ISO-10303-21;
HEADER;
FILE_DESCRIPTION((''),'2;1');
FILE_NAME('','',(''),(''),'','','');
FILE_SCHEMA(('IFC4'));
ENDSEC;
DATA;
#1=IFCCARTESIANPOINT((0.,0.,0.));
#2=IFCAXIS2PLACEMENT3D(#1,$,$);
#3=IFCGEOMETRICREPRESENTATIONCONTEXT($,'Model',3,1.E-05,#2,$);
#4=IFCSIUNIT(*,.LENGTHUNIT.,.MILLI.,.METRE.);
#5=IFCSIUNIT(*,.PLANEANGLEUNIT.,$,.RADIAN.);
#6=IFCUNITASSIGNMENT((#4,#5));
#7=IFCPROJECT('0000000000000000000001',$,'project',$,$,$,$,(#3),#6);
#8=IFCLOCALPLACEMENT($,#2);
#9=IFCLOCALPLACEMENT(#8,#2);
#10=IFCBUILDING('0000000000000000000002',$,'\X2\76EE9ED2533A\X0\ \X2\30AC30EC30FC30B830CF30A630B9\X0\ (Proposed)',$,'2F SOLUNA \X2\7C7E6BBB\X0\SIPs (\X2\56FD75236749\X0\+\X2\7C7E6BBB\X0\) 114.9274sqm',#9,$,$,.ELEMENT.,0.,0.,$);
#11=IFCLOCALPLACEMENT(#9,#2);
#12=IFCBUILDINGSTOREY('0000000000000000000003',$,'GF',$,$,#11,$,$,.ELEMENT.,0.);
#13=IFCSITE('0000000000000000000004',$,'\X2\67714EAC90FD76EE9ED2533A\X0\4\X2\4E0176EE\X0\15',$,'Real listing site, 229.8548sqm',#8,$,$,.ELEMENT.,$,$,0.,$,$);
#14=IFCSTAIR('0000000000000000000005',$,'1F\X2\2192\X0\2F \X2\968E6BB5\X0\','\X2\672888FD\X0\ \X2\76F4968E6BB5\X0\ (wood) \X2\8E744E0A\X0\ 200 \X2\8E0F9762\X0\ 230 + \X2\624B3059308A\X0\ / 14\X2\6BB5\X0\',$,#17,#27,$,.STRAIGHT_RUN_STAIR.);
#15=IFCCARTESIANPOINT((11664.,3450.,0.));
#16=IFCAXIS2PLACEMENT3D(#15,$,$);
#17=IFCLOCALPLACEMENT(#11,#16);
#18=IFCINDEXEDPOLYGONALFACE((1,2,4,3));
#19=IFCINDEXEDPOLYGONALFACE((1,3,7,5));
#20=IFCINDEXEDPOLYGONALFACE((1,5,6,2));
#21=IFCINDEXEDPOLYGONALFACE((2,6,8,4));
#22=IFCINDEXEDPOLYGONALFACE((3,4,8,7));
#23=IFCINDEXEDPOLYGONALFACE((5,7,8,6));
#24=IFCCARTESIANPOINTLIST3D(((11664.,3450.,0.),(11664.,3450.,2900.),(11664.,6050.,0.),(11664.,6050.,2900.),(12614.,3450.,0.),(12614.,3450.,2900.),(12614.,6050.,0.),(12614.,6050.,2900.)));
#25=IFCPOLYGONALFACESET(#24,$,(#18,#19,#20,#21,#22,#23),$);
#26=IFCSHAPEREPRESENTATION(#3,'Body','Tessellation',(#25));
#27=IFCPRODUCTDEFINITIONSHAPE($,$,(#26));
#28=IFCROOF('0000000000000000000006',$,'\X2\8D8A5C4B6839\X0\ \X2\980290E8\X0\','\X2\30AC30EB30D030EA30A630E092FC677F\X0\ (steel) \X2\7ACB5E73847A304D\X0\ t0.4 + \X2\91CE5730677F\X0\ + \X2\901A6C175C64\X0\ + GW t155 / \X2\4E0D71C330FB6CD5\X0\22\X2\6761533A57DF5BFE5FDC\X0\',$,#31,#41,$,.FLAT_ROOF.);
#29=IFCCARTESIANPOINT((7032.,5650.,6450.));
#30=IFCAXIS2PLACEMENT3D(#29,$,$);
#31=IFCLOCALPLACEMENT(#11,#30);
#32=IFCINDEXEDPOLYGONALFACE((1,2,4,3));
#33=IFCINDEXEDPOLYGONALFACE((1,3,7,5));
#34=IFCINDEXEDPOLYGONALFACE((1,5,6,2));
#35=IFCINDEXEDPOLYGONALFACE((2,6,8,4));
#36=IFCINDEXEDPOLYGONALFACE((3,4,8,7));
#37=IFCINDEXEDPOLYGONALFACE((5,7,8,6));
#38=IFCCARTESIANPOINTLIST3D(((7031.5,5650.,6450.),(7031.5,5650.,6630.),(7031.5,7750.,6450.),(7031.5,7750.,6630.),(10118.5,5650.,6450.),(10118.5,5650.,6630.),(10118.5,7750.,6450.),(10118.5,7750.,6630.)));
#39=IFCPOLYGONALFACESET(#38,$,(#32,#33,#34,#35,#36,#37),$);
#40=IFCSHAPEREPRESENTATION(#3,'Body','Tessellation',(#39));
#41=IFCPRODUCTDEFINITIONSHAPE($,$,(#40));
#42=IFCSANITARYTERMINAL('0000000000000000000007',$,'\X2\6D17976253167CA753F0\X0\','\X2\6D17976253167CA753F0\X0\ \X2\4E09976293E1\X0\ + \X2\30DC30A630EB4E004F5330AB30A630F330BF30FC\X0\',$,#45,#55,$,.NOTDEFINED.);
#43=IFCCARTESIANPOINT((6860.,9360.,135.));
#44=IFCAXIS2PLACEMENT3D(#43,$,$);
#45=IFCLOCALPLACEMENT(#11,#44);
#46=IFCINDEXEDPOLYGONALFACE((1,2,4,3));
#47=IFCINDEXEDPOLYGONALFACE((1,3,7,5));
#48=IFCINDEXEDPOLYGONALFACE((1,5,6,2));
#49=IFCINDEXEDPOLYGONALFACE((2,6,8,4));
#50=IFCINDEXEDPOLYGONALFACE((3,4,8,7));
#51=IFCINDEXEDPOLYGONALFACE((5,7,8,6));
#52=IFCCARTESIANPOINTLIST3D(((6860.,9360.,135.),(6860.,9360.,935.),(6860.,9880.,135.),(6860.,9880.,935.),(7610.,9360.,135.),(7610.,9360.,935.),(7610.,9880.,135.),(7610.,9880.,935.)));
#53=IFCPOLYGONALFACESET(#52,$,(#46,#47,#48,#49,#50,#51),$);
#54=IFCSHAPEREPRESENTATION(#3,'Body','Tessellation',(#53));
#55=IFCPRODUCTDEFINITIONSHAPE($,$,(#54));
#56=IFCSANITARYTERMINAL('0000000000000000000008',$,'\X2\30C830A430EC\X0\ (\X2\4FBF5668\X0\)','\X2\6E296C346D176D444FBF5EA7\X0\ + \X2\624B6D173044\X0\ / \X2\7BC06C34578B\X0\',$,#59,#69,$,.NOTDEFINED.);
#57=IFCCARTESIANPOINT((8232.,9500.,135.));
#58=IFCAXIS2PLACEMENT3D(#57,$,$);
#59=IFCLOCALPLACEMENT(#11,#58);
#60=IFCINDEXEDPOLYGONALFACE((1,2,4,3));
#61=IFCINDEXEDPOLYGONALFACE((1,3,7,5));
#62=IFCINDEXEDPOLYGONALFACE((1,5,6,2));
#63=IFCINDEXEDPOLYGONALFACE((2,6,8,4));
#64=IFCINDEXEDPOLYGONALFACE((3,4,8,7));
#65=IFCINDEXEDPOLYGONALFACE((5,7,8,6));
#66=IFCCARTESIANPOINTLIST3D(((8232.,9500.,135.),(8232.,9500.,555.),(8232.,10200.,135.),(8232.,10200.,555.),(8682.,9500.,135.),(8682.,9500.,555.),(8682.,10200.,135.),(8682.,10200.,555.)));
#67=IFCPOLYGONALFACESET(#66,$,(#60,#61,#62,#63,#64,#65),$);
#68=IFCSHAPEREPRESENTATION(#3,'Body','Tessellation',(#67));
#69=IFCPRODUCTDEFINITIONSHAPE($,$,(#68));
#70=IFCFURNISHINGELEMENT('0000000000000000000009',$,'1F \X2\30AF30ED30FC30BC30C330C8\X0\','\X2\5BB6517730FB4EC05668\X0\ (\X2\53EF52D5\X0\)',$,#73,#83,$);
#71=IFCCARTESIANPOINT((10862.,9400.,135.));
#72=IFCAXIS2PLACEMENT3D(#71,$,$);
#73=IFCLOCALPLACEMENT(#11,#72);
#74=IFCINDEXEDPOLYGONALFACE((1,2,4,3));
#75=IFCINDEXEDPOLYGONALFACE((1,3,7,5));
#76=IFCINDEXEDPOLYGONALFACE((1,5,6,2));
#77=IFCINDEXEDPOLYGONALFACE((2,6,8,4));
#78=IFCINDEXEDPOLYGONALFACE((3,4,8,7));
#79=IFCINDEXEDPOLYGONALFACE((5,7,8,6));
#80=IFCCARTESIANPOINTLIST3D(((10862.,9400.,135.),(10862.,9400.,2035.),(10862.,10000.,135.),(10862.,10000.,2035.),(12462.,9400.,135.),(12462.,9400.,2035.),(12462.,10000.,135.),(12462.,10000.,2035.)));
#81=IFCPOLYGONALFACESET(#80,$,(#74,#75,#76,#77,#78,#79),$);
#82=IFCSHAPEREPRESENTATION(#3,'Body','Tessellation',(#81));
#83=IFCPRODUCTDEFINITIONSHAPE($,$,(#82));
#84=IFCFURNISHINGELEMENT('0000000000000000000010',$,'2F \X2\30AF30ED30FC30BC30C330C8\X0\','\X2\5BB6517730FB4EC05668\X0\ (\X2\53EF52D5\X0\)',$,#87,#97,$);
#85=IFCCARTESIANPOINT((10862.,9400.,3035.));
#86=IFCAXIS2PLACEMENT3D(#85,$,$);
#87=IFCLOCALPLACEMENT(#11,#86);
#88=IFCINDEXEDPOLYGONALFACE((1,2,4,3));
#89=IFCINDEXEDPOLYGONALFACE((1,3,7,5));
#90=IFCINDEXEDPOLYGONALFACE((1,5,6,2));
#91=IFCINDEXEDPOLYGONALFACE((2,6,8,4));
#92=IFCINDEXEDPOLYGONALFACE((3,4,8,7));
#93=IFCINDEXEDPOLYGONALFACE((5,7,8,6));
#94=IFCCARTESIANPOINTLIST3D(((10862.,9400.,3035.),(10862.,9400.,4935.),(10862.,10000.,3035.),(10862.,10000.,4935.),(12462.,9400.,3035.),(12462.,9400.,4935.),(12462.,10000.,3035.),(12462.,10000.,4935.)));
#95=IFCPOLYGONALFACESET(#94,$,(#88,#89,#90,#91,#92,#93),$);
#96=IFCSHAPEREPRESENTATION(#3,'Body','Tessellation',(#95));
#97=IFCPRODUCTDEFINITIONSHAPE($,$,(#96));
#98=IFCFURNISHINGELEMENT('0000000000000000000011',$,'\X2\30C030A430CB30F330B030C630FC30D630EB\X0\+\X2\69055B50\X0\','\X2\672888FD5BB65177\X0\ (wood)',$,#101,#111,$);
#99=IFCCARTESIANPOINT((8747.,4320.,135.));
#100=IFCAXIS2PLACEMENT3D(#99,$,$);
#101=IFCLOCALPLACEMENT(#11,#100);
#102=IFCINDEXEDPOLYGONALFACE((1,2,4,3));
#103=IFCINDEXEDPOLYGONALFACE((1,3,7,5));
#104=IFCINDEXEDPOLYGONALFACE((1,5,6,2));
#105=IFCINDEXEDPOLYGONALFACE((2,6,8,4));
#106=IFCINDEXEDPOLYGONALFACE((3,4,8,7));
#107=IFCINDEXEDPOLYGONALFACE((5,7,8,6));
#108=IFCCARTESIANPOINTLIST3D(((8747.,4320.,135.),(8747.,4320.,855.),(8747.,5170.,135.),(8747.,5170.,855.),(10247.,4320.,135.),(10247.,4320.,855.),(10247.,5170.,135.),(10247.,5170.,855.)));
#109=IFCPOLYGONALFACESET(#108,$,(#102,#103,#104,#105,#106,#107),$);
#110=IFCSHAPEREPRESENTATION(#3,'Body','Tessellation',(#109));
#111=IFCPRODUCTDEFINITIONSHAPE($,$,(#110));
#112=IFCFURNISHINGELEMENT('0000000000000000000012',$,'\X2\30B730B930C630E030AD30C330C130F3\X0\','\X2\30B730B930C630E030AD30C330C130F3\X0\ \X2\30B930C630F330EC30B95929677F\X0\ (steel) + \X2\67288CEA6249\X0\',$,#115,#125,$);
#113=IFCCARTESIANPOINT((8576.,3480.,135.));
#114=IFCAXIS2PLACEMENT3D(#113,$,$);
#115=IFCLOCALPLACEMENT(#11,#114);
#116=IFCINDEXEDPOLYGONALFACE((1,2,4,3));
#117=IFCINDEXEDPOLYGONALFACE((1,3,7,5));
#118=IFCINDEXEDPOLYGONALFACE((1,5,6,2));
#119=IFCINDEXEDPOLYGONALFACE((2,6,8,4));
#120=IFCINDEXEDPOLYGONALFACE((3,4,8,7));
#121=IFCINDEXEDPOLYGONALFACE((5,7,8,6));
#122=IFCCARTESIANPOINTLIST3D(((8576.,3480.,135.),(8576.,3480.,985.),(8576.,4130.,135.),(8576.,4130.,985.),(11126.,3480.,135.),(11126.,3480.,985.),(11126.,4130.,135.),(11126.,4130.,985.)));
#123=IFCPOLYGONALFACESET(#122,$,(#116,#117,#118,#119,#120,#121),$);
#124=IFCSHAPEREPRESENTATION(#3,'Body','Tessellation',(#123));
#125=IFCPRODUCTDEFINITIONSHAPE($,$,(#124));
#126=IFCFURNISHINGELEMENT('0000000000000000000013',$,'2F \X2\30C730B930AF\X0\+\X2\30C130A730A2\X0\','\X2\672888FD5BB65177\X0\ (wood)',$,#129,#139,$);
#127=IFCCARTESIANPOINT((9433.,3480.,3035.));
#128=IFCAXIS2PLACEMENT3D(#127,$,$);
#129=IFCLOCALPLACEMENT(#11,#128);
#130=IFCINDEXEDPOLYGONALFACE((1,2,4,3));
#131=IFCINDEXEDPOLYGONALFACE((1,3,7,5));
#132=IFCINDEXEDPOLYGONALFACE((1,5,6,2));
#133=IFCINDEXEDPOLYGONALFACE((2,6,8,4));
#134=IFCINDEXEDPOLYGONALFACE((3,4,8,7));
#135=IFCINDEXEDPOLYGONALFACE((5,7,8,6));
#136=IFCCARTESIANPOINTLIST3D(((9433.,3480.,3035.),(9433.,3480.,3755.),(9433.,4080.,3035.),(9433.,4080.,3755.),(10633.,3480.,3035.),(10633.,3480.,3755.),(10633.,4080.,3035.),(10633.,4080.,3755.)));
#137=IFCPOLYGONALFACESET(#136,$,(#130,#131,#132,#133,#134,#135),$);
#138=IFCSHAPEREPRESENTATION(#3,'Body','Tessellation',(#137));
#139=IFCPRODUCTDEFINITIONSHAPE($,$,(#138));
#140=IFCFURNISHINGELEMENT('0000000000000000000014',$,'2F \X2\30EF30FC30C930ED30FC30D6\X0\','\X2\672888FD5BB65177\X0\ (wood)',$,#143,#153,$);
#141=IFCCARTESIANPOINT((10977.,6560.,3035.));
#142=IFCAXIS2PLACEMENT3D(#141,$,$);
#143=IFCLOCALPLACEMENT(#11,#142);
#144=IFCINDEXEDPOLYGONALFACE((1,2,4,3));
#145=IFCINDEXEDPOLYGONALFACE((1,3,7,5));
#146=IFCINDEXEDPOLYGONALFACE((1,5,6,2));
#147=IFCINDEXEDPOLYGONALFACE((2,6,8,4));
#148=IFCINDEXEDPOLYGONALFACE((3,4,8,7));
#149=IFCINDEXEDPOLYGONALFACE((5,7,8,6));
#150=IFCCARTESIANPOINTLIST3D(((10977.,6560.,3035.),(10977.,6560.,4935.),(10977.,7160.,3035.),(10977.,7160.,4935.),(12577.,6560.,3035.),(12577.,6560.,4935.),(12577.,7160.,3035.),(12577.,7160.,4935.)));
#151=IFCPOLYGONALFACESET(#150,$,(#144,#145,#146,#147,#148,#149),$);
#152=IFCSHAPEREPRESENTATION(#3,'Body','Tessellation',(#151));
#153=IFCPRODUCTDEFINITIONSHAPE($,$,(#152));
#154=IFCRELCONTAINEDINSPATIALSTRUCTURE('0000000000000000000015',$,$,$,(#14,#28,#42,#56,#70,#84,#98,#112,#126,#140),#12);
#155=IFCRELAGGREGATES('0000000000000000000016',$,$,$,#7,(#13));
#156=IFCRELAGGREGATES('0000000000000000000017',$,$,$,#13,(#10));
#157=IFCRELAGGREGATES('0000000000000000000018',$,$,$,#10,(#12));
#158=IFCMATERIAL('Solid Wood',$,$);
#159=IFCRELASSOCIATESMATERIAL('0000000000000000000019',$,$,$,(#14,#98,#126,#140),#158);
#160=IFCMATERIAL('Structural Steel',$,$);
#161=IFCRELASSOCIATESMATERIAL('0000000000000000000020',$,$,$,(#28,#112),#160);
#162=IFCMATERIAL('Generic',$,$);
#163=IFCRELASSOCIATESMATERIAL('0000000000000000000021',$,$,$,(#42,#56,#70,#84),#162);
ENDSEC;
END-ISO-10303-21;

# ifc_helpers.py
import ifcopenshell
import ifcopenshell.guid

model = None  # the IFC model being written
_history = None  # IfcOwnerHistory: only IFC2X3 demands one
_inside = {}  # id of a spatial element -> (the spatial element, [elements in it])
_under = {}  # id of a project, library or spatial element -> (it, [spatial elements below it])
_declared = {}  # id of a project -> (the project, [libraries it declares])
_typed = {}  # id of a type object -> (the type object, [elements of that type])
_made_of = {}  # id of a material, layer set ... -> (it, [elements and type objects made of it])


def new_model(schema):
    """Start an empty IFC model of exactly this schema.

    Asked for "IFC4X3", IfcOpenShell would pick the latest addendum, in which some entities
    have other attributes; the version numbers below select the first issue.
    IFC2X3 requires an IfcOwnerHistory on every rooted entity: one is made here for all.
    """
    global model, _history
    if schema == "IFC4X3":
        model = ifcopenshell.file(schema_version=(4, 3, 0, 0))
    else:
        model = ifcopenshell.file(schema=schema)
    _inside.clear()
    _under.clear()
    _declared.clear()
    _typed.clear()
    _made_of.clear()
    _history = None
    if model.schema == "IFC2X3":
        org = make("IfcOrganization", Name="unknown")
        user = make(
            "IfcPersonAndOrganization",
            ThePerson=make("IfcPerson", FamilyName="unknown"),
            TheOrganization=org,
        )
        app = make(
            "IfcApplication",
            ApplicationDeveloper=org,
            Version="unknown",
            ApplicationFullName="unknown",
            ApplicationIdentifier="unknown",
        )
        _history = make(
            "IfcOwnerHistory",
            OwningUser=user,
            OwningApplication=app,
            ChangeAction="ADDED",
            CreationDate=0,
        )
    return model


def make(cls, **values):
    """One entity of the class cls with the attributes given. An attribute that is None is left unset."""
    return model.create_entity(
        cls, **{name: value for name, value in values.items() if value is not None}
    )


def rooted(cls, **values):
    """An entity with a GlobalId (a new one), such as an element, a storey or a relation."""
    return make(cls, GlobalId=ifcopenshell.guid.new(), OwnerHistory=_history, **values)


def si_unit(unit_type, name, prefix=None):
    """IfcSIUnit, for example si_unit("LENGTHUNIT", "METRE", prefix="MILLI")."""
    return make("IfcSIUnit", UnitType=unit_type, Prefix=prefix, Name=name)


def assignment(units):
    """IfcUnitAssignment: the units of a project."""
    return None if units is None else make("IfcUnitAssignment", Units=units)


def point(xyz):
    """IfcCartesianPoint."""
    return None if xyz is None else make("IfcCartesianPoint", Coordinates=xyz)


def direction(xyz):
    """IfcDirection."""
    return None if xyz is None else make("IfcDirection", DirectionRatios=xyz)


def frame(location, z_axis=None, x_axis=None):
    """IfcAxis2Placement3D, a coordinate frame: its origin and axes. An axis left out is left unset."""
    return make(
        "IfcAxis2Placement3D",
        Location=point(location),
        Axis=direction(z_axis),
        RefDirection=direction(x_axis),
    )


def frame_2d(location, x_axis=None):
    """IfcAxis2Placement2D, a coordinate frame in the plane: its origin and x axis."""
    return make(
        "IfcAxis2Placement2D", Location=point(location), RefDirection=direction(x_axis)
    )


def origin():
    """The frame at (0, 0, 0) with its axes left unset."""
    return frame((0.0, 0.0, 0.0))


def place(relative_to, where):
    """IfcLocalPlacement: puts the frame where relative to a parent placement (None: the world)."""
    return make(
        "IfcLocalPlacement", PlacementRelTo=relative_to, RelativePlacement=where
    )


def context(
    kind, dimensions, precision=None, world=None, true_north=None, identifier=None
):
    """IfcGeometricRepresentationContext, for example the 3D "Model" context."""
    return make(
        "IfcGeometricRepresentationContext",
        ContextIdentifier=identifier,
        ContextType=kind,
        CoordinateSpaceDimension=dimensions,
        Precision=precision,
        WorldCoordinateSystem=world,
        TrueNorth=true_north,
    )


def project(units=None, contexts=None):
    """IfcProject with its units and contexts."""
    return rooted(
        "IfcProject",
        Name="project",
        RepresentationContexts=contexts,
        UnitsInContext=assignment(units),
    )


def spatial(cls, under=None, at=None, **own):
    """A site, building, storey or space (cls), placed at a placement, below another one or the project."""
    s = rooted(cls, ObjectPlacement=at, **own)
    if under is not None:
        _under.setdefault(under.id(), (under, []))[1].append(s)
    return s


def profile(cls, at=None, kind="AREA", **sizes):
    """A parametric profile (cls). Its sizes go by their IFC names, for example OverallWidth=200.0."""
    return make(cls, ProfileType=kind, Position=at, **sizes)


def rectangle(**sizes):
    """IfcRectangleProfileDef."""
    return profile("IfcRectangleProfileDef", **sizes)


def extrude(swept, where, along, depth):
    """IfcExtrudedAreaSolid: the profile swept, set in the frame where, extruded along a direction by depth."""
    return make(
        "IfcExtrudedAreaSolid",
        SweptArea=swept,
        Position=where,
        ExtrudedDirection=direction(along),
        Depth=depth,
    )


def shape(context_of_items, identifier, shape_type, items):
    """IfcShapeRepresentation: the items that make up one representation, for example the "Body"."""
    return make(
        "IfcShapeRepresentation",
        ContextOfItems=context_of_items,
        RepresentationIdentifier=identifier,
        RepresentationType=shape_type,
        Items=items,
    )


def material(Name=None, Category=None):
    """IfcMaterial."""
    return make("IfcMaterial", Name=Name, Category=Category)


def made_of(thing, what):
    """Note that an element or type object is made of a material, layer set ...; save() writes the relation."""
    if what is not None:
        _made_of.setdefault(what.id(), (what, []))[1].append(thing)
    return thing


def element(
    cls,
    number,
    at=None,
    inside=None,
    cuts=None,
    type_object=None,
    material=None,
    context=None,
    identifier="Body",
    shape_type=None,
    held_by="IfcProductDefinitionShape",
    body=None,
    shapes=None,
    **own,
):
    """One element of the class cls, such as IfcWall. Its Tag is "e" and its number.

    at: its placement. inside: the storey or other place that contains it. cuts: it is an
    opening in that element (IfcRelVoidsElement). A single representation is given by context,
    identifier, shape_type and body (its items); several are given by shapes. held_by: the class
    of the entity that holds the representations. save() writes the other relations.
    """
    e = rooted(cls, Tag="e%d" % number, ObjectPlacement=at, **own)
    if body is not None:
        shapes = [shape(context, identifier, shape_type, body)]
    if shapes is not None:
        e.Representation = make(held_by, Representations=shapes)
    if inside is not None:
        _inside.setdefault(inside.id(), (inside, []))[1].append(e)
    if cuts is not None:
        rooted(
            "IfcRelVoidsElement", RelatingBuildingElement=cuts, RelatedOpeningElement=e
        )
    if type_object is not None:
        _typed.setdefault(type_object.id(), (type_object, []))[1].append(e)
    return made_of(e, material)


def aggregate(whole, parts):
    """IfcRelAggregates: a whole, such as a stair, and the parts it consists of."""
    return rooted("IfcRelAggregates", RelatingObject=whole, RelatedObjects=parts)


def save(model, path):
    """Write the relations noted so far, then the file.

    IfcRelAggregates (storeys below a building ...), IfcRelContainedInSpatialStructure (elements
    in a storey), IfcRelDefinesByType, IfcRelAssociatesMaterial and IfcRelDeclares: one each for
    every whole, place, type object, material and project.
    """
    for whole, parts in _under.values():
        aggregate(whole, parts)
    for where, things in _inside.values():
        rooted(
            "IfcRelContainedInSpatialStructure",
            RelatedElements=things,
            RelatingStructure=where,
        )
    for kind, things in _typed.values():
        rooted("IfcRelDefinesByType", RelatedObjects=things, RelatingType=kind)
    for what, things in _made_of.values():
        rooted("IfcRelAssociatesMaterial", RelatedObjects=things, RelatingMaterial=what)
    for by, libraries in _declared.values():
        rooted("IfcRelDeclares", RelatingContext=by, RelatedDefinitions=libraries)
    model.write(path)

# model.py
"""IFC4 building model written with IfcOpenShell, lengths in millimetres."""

from ifc_helpers import new_model, si_unit, frame, frame_2d, origin, place, context, project, spatial, rectangle, extrude, material, element, save


model = new_model("IFC4")

# Units and contexts
model_context = context("Model", 3, precision=1e-05, world=origin())
ifc_project = project(units=[si_unit("LENGTHUNIT", "METRE", prefix="MILLI"), si_unit("PLANEANGLEUNIT", "RADIAN")], contexts=[model_context])

# Site, building, storey
site_placement = place(None, origin())
site = spatial("IfcSite", under=ifc_project, at=site_placement, Name="東京都目黒区4丁目15", ObjectType="Real listing site, 229.8548sqm", CompositionType="ELEMENT", RefElevation=0.0)
building_placement = place(site_placement, origin())
building = spatial("IfcBuilding", under=site, at=building_placement, Name="目黒区 ガレージハウス (Proposed)", ObjectType="2F SOLUNA 籾殻SIPs (国産杉+籾殻) 114.9274sqm", CompositionType="ELEMENT", ElevationOfRefHeight=0.0, ElevationOfTerrain=0.0)
storey_placement = place(building_placement, origin())
storey = spatial("IfcBuildingStorey", under=building, at=storey_placement, Name="GF", CompositionType="ELEMENT", Elevation=0.0)

# Shared definitions
ifc_material_1 = material(Name="Solid Wood")

# Stair
stair_placement = place(storey_placement, frame((11664.0, 3450.0, 0.0)))
element("IfcStair", 1, at=stair_placement, inside=storey, material=ifc_material_1, Name="1F→2F 階段", Description="木製 直階段 (wood) 蹴上 200 踏面 230 + 手すり / 14段", PredefinedType="STRAIGHT_RUN_STAIR", context=model_context, shape_type="SweptSolid", body=[
    extrude(rectangle(XDim=950.0, YDim=2600.0, at=frame_2d((475.0, 1300.0))), frame((11664.0, 3450.0, 0.0)), (0.0, 0.0, 1.0), 2900.0),
])

# Roof
ifc_material_2 = material(Name="Structural Steel")
roof_placement = place(storey_placement, frame((7032.0, 5650.0, 6450.0)))
element("IfcRoof", 2, at=roof_placement, inside=storey, material=ifc_material_2, Name="越屋根 頂部", Description="ガルバリウム鋼板 (steel) 立平葺き t0.4 + 野地板 + 通気層 + GW t155 / 不燃・法22条区域対応", PredefinedType="FLAT_ROOF", context=model_context, shape_type="SweptSolid", body=[
    extrude(rectangle(XDim=3087.0, YDim=2100.0, at=frame_2d((1543.0, 1050.0))), frame((7032.0, 5650.0, 6450.0)), (0.0, 0.0, 1.0), 180.0),
])

# Sanitary terminals
ifc_material_3 = material(Name="Generic")
sanitary_terminal_1_placement = place(storey_placement, frame((6860.0, 9360.0, 135.0)))
element("IfcSanitaryTerminal", 3, at=sanitary_terminal_1_placement, inside=storey, material=ifc_material_3, Name="洗面化粧台", Description="洗面化粧台 三面鏡 + ボウル一体カウンター", PredefinedType="NOTDEFINED", context=model_context, shape_type="SweptSolid", body=[
    extrude(rectangle(XDim=750.0, YDim=520.0, at=frame_2d((375.0, 260.0))), frame((6860.0, 9360.0, 135.0)), (0.0, 0.0, 1.0), 800.0),
])
sanitary_terminal_2_placement = place(storey_placement, frame((8232.0, 9500.0, 135.0)))
element("IfcSanitaryTerminal", 4, at=sanitary_terminal_2_placement, inside=storey, material=ifc_material_3, Name="トイレ (便器)", Description="温水洗浄便座 + 手洗い / 節水型", PredefinedType="NOTDEFINED", context=model_context, shape_type="SweptSolid", body=[
    extrude(rectangle(XDim=450.0, YDim=700.0, at=frame_2d((225.0, 350.0))), frame((8232.0, 9500.0, 135.0)), (0.0, 0.0, 1.0), 420.0),
])

# Furnishing elements
furnishing_1_placement = place(storey_placement, frame((10862.0, 9400.0, 135.0)))
element("IfcFurnishingElement", 5, at=furnishing_1_placement, inside=storey, material=ifc_material_3, Name="1F クローゼット", Description="家具・什器 (可動)", context=model_context, shape_type="SweptSolid", body=[
    extrude(rectangle(XDim=1600.0, YDim=600.0, at=frame_2d((800.0, 300.0))), frame((10862.0, 9400.0, 135.0)), (0.0, 0.0, 1.0), 1900.0),
])
furnishing_2_placement = place(storey_placement, frame((10862.0, 9400.0, 3035.0)))
element("IfcFurnishingElement", 6, at=furnishing_2_placement, inside=storey, material=ifc_material_3, Name="2F クローゼット", Description="家具・什器 (可動)", context=model_context, shape_type="SweptSolid", body=[
    extrude(rectangle(XDim=1600.0, YDim=600.0, at=frame_2d((800.0, 300.0))), frame((10862.0, 9400.0, 3035.0)), (0.0, 0.0, 1.0), 1900.0),
])
furnishing_3_placement = place(storey_placement, frame((8747.0, 4320.0, 135.0)))
element("IfcFurnishingElement", 7, at=furnishing_3_placement, inside=storey, material=ifc_material_1, Name="ダイニングテーブル+椅子", Description="木製家具 (wood)", context=model_context, shape_type="SweptSolid", body=[
    extrude(rectangle(XDim=1500.0, YDim=850.0, at=frame_2d((750.0, 425.0))), frame((8747.0, 4320.0, 135.0)), (0.0, 0.0, 1.0), 720.0),
])
furnishing_4_placement = place(storey_placement, frame((8576.0, 3480.0, 135.0)))
element("IfcFurnishingElement", 8, at=furnishing_4_placement, inside=storey, material=ifc_material_2, Name="システムキッチン", Description="システムキッチン ステンレス天板 (steel) + 木質扉", context=model_context, shape_type="SweptSolid", body=[
    extrude(rectangle(XDim=2550.0, YDim=650.0, at=frame_2d((1275.0, 325.0))), frame((8576.0, 3480.0, 135.0)), (0.0, 0.0, 1.0), 850.0),
])
furnishing_5_placement = place(storey_placement, frame((9433.0, 3480.0, 3035.0)))
element("IfcFurnishingElement", 9, at=furnishing_5_placement, inside=storey, material=ifc_material_1, Name="2F デスク+チェア", Description="木製家具 (wood)", context=model_context, shape_type="SweptSolid", body=[
    extrude(rectangle(XDim=1200.0, YDim=600.0, at=frame_2d((600.0, 300.0))), frame((9433.0, 3480.0, 3035.0)), (0.0, 0.0, 1.0), 720.0),
])
furnishing_6_placement = place(storey_placement, frame((10977.0, 6560.0, 3035.0)))
element("IfcFurnishingElement", 10, at=furnishing_6_placement, inside=storey, material=ifc_material_1, Name="2F ワードローブ", Description="木製家具 (wood)", context=model_context, shape_type="SweptSolid", body=[
    extrude(rectangle(XDim=1600.0, YDim=600.0, at=frame_2d((800.0, 300.0))), frame((10977.0, 6560.0, 3035.0)), (0.0, 0.0, 1.0), 1900.0),
])

save(model, "model.ifc")
